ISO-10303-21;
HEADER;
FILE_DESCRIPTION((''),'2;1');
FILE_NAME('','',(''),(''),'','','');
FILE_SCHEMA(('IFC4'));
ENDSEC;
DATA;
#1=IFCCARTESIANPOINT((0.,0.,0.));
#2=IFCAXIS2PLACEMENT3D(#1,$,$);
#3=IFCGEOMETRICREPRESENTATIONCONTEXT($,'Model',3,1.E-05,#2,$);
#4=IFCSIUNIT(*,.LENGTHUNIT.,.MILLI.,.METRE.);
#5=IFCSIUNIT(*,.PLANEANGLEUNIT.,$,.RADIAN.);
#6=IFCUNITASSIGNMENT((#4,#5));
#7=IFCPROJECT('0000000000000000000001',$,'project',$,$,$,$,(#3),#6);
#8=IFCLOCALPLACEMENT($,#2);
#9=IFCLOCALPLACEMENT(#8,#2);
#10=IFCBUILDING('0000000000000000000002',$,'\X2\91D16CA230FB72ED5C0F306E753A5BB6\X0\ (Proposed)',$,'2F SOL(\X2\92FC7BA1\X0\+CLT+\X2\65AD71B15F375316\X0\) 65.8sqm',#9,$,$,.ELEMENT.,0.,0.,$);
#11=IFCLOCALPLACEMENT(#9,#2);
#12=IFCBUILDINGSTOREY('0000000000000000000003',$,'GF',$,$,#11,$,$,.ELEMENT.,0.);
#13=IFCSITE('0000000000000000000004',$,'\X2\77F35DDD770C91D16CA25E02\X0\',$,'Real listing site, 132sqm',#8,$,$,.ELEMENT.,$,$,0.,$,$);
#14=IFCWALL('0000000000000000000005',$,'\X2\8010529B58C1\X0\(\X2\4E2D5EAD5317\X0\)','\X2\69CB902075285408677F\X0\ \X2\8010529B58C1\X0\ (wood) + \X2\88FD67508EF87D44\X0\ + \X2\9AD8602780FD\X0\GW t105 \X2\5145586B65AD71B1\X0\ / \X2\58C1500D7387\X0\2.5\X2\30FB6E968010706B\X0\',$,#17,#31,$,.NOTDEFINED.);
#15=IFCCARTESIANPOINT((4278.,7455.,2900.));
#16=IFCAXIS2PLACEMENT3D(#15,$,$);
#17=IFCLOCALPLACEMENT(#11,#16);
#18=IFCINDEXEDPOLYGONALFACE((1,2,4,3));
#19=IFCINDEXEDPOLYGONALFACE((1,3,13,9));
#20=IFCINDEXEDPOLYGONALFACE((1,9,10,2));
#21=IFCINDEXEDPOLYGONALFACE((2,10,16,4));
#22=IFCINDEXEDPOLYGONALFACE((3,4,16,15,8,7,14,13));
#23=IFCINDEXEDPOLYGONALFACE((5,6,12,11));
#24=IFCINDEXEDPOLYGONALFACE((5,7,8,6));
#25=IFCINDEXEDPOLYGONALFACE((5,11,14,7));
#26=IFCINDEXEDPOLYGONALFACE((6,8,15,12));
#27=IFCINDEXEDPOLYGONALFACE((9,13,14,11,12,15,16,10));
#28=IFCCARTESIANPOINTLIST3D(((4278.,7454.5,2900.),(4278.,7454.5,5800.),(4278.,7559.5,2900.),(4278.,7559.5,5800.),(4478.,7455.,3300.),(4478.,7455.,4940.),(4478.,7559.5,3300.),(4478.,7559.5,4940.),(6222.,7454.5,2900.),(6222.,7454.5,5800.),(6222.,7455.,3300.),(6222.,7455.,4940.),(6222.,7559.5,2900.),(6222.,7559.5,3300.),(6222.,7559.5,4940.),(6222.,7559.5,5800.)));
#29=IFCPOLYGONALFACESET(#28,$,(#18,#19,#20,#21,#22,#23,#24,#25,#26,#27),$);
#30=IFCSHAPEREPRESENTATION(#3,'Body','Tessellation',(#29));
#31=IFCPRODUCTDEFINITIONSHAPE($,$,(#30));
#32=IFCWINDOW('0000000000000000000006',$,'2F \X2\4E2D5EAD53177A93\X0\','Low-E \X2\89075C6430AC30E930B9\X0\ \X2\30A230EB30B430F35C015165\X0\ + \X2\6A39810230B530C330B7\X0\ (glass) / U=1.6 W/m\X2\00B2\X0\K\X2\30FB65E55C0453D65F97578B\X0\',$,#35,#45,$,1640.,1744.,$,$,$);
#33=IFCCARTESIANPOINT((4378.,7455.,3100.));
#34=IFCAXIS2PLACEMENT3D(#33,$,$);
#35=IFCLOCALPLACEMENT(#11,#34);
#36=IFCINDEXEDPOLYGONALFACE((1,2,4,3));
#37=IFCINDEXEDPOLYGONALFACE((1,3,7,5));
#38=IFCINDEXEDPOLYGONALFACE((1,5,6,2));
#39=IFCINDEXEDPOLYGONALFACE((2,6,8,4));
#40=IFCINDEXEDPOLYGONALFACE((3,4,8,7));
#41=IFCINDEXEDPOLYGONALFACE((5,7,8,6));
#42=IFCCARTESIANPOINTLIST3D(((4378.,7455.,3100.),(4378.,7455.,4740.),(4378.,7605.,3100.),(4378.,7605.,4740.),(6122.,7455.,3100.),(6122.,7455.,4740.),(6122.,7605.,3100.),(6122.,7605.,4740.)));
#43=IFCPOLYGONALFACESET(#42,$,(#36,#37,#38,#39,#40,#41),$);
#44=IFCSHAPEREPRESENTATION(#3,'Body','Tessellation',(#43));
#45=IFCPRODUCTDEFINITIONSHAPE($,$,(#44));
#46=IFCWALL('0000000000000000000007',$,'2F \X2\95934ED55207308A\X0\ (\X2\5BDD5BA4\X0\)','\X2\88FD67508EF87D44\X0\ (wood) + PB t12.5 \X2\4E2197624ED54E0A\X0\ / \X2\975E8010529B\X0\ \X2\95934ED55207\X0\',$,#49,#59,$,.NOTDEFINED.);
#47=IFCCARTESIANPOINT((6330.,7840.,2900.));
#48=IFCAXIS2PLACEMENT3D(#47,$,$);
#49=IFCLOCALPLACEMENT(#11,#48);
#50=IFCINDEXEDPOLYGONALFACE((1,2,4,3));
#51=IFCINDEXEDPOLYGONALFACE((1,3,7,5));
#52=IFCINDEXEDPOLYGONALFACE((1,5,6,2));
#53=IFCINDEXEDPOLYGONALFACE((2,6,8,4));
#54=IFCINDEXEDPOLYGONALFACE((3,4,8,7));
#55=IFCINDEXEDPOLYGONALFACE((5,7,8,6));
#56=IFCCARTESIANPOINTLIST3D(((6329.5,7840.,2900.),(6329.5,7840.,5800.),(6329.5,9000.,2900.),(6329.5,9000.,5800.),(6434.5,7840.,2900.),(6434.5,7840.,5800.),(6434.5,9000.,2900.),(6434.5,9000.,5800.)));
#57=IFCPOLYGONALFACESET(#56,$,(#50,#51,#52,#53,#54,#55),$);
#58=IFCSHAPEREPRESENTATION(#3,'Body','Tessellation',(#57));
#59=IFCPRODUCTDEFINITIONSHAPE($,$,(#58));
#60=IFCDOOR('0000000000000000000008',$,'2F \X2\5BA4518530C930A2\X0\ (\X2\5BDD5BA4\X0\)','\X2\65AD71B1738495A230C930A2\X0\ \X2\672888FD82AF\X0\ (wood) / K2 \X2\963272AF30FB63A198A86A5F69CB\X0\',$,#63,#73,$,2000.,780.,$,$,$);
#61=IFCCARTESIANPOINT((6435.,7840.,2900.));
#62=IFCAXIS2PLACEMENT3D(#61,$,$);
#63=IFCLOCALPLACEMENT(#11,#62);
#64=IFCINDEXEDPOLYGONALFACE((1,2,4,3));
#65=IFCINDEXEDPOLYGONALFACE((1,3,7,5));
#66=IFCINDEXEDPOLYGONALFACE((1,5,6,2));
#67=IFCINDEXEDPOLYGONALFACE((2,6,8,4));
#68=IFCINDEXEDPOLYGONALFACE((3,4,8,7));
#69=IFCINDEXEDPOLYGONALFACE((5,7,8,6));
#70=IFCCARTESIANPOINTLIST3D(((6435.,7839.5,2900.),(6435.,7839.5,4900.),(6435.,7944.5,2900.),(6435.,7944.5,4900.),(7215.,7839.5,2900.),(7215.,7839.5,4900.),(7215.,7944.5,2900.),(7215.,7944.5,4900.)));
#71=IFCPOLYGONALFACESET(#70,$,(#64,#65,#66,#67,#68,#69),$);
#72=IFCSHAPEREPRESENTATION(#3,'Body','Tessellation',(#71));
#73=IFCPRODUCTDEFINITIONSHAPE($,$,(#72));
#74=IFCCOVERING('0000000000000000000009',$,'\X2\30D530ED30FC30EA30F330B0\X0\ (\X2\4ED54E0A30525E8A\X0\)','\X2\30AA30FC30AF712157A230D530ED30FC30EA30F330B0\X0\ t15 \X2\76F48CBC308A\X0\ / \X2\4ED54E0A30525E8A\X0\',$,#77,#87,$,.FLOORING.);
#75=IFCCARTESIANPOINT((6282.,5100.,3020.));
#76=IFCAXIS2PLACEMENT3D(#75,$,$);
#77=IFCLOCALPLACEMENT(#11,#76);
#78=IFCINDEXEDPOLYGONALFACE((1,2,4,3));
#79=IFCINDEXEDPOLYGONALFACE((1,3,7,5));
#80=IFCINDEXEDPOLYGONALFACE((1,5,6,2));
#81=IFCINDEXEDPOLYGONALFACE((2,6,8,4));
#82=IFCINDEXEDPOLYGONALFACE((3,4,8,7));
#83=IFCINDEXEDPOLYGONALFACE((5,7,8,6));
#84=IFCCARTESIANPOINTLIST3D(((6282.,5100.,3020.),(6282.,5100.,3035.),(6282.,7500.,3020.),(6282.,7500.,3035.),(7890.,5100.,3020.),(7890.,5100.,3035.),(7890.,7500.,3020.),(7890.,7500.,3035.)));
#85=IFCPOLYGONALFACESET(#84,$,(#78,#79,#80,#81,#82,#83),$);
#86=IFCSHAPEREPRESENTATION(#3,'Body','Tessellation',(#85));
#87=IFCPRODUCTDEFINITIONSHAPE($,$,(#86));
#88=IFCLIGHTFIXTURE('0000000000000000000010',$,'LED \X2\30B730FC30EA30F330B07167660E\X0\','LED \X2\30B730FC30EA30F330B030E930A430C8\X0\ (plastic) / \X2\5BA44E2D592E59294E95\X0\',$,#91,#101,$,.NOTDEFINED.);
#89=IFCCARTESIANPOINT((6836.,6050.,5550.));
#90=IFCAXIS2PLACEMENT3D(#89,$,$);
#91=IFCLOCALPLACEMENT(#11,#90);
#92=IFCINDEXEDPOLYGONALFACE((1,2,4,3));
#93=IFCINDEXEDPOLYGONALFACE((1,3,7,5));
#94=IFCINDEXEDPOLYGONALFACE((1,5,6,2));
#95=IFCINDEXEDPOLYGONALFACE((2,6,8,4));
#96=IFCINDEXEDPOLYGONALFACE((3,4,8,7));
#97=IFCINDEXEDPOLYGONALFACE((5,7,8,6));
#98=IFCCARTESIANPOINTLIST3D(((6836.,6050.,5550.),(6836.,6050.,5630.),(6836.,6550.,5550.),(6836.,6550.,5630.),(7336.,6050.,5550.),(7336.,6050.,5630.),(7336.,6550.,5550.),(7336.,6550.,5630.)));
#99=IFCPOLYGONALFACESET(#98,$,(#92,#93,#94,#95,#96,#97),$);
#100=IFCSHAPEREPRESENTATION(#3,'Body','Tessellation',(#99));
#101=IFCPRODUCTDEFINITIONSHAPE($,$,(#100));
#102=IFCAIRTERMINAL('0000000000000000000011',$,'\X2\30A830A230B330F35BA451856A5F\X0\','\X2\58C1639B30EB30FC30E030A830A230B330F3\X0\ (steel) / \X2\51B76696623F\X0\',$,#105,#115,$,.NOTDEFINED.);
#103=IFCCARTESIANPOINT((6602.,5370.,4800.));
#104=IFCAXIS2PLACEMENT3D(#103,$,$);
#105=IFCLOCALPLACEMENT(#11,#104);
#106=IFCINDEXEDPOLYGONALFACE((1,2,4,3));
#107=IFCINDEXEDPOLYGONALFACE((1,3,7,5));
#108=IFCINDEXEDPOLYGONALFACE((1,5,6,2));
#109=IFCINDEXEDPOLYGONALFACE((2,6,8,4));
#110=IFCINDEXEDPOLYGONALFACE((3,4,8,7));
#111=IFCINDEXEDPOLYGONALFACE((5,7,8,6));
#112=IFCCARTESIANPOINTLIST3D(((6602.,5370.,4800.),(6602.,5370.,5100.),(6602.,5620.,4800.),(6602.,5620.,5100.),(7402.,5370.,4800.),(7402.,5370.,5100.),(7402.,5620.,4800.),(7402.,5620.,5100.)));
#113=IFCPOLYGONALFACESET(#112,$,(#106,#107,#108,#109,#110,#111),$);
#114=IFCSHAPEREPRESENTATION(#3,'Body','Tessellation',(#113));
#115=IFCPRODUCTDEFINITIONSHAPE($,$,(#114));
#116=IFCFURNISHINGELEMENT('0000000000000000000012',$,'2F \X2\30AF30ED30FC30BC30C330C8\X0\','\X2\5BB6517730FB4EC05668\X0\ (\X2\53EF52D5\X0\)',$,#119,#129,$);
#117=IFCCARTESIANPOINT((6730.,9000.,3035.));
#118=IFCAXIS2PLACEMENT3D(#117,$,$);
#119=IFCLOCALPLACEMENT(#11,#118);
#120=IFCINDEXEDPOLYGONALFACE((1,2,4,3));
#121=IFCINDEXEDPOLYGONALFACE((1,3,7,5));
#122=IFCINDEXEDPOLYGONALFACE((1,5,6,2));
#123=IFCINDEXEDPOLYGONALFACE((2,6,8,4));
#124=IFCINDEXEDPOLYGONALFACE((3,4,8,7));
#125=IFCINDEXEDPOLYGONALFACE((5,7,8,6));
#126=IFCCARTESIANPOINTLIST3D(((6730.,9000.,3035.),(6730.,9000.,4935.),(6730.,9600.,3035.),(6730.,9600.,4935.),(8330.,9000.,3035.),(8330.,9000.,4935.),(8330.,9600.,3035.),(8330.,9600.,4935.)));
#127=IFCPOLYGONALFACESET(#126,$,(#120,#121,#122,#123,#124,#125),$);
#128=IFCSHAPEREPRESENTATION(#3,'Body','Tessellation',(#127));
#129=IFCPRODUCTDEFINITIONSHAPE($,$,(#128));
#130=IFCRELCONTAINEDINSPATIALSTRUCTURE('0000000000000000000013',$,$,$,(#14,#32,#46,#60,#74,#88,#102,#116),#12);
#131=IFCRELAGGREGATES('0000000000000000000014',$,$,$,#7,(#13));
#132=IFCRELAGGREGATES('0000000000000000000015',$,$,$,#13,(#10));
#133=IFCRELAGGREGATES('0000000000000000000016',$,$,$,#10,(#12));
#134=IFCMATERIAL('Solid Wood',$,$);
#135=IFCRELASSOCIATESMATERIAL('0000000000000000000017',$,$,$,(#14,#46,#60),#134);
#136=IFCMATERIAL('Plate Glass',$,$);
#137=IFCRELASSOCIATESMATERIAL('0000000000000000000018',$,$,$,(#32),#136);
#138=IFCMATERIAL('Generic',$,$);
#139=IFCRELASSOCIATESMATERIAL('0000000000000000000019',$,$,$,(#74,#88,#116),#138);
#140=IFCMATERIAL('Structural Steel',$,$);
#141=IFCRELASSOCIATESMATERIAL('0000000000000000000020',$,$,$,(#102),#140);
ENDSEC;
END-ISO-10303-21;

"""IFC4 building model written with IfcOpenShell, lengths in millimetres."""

from ifc_helpers import new_model, si_unit, frame, frame_2d, origin, place, context, project, spatial, rectangle, extrude, material, element, fill, save


model = new_model("IFC4")

# Units and contexts
model_context = context("Model", 3, precision=1e-05, world=origin())
ifc_project = project(units=[si_unit("LENGTHUNIT", "METRE", prefix="MILLI"), si_unit("PLANEANGLEUNIT", "RADIAN")], contexts=[model_context])

# Site, building, storey
site_placement = place(None, origin())
site = spatial("IfcSite", under=ifc_project, at=site_placement, Name="石川県金沢市", ObjectType="Real listing site, 132sqm", CompositionType="ELEMENT", RefElevation=0.0)
building_placement = place(site_placement, origin())
building = spatial("IfcBuilding", under=site, at=building_placement, Name="金沢・狭小の町家 (Proposed)", ObjectType="2F SOL(鋼管+CLT+断熱強化) 65.8sqm", CompositionType="ELEMENT", ElevationOfRefHeight=0.0, ElevationOfTerrain=0.0)
storey_placement = place(building_placement, origin())
storey = spatial("IfcBuildingStorey", under=building, at=storey_placement, Name="GF", CompositionType="ELEMENT", Elevation=0.0)

# Shared definitions
ifc_material_1 = material(Name="Solid Wood")

# Wall, opening, window
wall_1_placement = place(storey_placement, frame((4278.0, 7455.0, 2900.0)))
wall_1 = element("IfcWall", 1, at=wall_1_placement, inside=storey, material=ifc_material_1, Name="耐力壁(中庭北)", Description="構造用合板 耐力壁 (wood) + 製材軸組 + 高性能GW t105 充填断熱 / 壁倍率2.5・準耐火", PredefinedType="NOTDEFINED", context=model_context, shape_type="SweptSolid", body=[
    extrude(rectangle(XDim=1944.0, YDim=105.0, at=frame_2d((972.0, 52.0))), frame((4278.0, 7455.0, 2900.0)), (0.0, 0.0, 1.0), 2900.0),
])
opening_placement = place(storey_placement, frame((4378.0, 7455.0, 3100.0)))
opening = element("IfcOpeningElement", 2, at=opening_placement, cuts=wall_1, PredefinedType="NOTDEFINED", context=model_context, shape_type="SweptSolid", body=[
    extrude(rectangle(XDim=1744.0, YDim=150.0, at=frame_2d((872.0, 75.0))), frame((4378.0, 7455.0, 3100.0)), (0.0, 0.0, 1.0), 1640.0),
])
ifc_material_2 = material(Name="Plate Glass")
window_placement = place(storey_placement, frame((4378.0, 7455.0, 3100.0)))
window = element("IfcWindow", 3, at=window_placement, inside=storey, material=ifc_material_2, Name="2F 中庭北窓", Description="Low-E 複層ガラス アルゴン封入 + 樹脂サッシ (glass) / U=1.6 W/m²K・日射取得型", OverallHeight=1640.0, OverallWidth=1744.0, context=model_context, shape_type="SweptSolid", body=[
    extrude(rectangle(XDim=1744.0, YDim=150.0, at=frame_2d((872.0, 75.0))), frame((4378.0, 7455.0, 3100.0)), (0.0, 0.0, 1.0), 1640.0),
])
fill(opening, window)

# Wall
wall_2_placement = place(storey_placement, frame((6330.0, 7840.0, 2900.0)))
element("IfcWall", 4, at=wall_2_placement, inside=storey, material=ifc_material_1, Name="2F 間仕切り (寝室)", Description="製材軸組 (wood) + PB t12.5 両面仕上 / 非耐力 間仕切", PredefinedType="NOTDEFINED", context=model_context, shape_type="SweptSolid", body=[
    extrude(rectangle(XDim=105.0, YDim=1160.0, at=frame_2d((52.0, 580.0))), frame((6330.0, 7840.0, 2900.0)), (0.0, 0.0, 1.0), 2900.0),
])

# Door
door_placement = place(storey_placement, frame((6435.0, 7840.0, 2900.0)))
element("IfcDoor", 5, at=door_placement, inside=storey, material=ifc_material_1, Name="2F 室内ドア (寝室)", Description="断熱玄関ドア 木製芯 (wood) / K2 防犯・採風機構", OverallHeight=2000.0, OverallWidth=780.0, context=model_context, shape_type="SweptSolid", body=[
    extrude(rectangle(XDim=780.0, YDim=105.0, at=frame_2d((390.0, 52.0))), frame((6435.0, 7840.0, 2900.0)), (0.0, 0.0, 1.0), 2000.0),
])

# Covering
ifc_material_3 = material(Name="Generic")
covering_placement = place(storey_placement, frame((6282.0, 5100.0, 3020.0)))
element("IfcCovering", 6, at=covering_placement, inside=storey, material=ifc_material_3, Name="フローリング (仕上げ床)", Description="オーク無垢フローリング t15 直貼り / 仕上げ床", PredefinedType="FLOORING", context=model_context, shape_type="SweptSolid", body=[
    extrude(rectangle(XDim=1608.0, YDim=2400.0, at=frame_2d((804.0, 1200.0))), frame((6282.0, 5100.0, 3020.0)), (0.0, 0.0, 1.0), 15.0),
])

# Light fixture
light_fixture_placement = place(storey_placement, frame((6836.0, 6050.0, 5550.0)))
element("IfcLightFixture", 7, at=light_fixture_placement, inside=storey, material=ifc_material_3, Name="LED シーリング照明", Description="LED シーリングライト (plastic) / 室中央天井", PredefinedType="NOTDEFINED", context=model_context, shape_type="SweptSolid", body=[
    extrude(rectangle(XDim=500.0, YDim=500.0, at=frame_2d((250.0, 250.0))), frame((6836.0, 6050.0, 5550.0)), (0.0, 0.0, 1.0), 80.0),
])

# Air terminal
ifc_material_4 = material(Name="Structural Steel")
air_terminal_placement = place(storey_placement, frame((6602.0, 5370.0, 4800.0)))
element("IfcAirTerminal", 8, at=air_terminal_placement, inside=storey, material=ifc_material_4, Name="エアコン室内機", Description="壁掛ルームエアコン (steel) / 冷暖房", PredefinedType="NOTDEFINED", context=model_context, shape_type="SweptSolid", body=[
    extrude(rectangle(XDim=800.0, YDim=250.0, at=frame_2d((400.0, 125.0))), frame((6602.0, 5370.0, 4800.0)), (0.0, 0.0, 1.0), 300.0),
])

# Furnishing element
furnishing_placement = place(storey_placement, frame((6730.0, 9000.0, 3035.0)))
element("IfcFurnishingElement", 9, at=furnishing_placement, inside=storey, material=ifc_material_3, Name="2F クローゼット", Description="家具・什器 (可動)", context=model_context, shape_type="SweptSolid", body=[
    extrude(rectangle(XDim=1600.0, YDim=600.0, at=frame_2d((800.0, 300.0))), frame((6730.0, 9000.0, 3035.0)), (0.0, 0.0, 1.0), 1900.0),
])

save(model, "model.ifc")
